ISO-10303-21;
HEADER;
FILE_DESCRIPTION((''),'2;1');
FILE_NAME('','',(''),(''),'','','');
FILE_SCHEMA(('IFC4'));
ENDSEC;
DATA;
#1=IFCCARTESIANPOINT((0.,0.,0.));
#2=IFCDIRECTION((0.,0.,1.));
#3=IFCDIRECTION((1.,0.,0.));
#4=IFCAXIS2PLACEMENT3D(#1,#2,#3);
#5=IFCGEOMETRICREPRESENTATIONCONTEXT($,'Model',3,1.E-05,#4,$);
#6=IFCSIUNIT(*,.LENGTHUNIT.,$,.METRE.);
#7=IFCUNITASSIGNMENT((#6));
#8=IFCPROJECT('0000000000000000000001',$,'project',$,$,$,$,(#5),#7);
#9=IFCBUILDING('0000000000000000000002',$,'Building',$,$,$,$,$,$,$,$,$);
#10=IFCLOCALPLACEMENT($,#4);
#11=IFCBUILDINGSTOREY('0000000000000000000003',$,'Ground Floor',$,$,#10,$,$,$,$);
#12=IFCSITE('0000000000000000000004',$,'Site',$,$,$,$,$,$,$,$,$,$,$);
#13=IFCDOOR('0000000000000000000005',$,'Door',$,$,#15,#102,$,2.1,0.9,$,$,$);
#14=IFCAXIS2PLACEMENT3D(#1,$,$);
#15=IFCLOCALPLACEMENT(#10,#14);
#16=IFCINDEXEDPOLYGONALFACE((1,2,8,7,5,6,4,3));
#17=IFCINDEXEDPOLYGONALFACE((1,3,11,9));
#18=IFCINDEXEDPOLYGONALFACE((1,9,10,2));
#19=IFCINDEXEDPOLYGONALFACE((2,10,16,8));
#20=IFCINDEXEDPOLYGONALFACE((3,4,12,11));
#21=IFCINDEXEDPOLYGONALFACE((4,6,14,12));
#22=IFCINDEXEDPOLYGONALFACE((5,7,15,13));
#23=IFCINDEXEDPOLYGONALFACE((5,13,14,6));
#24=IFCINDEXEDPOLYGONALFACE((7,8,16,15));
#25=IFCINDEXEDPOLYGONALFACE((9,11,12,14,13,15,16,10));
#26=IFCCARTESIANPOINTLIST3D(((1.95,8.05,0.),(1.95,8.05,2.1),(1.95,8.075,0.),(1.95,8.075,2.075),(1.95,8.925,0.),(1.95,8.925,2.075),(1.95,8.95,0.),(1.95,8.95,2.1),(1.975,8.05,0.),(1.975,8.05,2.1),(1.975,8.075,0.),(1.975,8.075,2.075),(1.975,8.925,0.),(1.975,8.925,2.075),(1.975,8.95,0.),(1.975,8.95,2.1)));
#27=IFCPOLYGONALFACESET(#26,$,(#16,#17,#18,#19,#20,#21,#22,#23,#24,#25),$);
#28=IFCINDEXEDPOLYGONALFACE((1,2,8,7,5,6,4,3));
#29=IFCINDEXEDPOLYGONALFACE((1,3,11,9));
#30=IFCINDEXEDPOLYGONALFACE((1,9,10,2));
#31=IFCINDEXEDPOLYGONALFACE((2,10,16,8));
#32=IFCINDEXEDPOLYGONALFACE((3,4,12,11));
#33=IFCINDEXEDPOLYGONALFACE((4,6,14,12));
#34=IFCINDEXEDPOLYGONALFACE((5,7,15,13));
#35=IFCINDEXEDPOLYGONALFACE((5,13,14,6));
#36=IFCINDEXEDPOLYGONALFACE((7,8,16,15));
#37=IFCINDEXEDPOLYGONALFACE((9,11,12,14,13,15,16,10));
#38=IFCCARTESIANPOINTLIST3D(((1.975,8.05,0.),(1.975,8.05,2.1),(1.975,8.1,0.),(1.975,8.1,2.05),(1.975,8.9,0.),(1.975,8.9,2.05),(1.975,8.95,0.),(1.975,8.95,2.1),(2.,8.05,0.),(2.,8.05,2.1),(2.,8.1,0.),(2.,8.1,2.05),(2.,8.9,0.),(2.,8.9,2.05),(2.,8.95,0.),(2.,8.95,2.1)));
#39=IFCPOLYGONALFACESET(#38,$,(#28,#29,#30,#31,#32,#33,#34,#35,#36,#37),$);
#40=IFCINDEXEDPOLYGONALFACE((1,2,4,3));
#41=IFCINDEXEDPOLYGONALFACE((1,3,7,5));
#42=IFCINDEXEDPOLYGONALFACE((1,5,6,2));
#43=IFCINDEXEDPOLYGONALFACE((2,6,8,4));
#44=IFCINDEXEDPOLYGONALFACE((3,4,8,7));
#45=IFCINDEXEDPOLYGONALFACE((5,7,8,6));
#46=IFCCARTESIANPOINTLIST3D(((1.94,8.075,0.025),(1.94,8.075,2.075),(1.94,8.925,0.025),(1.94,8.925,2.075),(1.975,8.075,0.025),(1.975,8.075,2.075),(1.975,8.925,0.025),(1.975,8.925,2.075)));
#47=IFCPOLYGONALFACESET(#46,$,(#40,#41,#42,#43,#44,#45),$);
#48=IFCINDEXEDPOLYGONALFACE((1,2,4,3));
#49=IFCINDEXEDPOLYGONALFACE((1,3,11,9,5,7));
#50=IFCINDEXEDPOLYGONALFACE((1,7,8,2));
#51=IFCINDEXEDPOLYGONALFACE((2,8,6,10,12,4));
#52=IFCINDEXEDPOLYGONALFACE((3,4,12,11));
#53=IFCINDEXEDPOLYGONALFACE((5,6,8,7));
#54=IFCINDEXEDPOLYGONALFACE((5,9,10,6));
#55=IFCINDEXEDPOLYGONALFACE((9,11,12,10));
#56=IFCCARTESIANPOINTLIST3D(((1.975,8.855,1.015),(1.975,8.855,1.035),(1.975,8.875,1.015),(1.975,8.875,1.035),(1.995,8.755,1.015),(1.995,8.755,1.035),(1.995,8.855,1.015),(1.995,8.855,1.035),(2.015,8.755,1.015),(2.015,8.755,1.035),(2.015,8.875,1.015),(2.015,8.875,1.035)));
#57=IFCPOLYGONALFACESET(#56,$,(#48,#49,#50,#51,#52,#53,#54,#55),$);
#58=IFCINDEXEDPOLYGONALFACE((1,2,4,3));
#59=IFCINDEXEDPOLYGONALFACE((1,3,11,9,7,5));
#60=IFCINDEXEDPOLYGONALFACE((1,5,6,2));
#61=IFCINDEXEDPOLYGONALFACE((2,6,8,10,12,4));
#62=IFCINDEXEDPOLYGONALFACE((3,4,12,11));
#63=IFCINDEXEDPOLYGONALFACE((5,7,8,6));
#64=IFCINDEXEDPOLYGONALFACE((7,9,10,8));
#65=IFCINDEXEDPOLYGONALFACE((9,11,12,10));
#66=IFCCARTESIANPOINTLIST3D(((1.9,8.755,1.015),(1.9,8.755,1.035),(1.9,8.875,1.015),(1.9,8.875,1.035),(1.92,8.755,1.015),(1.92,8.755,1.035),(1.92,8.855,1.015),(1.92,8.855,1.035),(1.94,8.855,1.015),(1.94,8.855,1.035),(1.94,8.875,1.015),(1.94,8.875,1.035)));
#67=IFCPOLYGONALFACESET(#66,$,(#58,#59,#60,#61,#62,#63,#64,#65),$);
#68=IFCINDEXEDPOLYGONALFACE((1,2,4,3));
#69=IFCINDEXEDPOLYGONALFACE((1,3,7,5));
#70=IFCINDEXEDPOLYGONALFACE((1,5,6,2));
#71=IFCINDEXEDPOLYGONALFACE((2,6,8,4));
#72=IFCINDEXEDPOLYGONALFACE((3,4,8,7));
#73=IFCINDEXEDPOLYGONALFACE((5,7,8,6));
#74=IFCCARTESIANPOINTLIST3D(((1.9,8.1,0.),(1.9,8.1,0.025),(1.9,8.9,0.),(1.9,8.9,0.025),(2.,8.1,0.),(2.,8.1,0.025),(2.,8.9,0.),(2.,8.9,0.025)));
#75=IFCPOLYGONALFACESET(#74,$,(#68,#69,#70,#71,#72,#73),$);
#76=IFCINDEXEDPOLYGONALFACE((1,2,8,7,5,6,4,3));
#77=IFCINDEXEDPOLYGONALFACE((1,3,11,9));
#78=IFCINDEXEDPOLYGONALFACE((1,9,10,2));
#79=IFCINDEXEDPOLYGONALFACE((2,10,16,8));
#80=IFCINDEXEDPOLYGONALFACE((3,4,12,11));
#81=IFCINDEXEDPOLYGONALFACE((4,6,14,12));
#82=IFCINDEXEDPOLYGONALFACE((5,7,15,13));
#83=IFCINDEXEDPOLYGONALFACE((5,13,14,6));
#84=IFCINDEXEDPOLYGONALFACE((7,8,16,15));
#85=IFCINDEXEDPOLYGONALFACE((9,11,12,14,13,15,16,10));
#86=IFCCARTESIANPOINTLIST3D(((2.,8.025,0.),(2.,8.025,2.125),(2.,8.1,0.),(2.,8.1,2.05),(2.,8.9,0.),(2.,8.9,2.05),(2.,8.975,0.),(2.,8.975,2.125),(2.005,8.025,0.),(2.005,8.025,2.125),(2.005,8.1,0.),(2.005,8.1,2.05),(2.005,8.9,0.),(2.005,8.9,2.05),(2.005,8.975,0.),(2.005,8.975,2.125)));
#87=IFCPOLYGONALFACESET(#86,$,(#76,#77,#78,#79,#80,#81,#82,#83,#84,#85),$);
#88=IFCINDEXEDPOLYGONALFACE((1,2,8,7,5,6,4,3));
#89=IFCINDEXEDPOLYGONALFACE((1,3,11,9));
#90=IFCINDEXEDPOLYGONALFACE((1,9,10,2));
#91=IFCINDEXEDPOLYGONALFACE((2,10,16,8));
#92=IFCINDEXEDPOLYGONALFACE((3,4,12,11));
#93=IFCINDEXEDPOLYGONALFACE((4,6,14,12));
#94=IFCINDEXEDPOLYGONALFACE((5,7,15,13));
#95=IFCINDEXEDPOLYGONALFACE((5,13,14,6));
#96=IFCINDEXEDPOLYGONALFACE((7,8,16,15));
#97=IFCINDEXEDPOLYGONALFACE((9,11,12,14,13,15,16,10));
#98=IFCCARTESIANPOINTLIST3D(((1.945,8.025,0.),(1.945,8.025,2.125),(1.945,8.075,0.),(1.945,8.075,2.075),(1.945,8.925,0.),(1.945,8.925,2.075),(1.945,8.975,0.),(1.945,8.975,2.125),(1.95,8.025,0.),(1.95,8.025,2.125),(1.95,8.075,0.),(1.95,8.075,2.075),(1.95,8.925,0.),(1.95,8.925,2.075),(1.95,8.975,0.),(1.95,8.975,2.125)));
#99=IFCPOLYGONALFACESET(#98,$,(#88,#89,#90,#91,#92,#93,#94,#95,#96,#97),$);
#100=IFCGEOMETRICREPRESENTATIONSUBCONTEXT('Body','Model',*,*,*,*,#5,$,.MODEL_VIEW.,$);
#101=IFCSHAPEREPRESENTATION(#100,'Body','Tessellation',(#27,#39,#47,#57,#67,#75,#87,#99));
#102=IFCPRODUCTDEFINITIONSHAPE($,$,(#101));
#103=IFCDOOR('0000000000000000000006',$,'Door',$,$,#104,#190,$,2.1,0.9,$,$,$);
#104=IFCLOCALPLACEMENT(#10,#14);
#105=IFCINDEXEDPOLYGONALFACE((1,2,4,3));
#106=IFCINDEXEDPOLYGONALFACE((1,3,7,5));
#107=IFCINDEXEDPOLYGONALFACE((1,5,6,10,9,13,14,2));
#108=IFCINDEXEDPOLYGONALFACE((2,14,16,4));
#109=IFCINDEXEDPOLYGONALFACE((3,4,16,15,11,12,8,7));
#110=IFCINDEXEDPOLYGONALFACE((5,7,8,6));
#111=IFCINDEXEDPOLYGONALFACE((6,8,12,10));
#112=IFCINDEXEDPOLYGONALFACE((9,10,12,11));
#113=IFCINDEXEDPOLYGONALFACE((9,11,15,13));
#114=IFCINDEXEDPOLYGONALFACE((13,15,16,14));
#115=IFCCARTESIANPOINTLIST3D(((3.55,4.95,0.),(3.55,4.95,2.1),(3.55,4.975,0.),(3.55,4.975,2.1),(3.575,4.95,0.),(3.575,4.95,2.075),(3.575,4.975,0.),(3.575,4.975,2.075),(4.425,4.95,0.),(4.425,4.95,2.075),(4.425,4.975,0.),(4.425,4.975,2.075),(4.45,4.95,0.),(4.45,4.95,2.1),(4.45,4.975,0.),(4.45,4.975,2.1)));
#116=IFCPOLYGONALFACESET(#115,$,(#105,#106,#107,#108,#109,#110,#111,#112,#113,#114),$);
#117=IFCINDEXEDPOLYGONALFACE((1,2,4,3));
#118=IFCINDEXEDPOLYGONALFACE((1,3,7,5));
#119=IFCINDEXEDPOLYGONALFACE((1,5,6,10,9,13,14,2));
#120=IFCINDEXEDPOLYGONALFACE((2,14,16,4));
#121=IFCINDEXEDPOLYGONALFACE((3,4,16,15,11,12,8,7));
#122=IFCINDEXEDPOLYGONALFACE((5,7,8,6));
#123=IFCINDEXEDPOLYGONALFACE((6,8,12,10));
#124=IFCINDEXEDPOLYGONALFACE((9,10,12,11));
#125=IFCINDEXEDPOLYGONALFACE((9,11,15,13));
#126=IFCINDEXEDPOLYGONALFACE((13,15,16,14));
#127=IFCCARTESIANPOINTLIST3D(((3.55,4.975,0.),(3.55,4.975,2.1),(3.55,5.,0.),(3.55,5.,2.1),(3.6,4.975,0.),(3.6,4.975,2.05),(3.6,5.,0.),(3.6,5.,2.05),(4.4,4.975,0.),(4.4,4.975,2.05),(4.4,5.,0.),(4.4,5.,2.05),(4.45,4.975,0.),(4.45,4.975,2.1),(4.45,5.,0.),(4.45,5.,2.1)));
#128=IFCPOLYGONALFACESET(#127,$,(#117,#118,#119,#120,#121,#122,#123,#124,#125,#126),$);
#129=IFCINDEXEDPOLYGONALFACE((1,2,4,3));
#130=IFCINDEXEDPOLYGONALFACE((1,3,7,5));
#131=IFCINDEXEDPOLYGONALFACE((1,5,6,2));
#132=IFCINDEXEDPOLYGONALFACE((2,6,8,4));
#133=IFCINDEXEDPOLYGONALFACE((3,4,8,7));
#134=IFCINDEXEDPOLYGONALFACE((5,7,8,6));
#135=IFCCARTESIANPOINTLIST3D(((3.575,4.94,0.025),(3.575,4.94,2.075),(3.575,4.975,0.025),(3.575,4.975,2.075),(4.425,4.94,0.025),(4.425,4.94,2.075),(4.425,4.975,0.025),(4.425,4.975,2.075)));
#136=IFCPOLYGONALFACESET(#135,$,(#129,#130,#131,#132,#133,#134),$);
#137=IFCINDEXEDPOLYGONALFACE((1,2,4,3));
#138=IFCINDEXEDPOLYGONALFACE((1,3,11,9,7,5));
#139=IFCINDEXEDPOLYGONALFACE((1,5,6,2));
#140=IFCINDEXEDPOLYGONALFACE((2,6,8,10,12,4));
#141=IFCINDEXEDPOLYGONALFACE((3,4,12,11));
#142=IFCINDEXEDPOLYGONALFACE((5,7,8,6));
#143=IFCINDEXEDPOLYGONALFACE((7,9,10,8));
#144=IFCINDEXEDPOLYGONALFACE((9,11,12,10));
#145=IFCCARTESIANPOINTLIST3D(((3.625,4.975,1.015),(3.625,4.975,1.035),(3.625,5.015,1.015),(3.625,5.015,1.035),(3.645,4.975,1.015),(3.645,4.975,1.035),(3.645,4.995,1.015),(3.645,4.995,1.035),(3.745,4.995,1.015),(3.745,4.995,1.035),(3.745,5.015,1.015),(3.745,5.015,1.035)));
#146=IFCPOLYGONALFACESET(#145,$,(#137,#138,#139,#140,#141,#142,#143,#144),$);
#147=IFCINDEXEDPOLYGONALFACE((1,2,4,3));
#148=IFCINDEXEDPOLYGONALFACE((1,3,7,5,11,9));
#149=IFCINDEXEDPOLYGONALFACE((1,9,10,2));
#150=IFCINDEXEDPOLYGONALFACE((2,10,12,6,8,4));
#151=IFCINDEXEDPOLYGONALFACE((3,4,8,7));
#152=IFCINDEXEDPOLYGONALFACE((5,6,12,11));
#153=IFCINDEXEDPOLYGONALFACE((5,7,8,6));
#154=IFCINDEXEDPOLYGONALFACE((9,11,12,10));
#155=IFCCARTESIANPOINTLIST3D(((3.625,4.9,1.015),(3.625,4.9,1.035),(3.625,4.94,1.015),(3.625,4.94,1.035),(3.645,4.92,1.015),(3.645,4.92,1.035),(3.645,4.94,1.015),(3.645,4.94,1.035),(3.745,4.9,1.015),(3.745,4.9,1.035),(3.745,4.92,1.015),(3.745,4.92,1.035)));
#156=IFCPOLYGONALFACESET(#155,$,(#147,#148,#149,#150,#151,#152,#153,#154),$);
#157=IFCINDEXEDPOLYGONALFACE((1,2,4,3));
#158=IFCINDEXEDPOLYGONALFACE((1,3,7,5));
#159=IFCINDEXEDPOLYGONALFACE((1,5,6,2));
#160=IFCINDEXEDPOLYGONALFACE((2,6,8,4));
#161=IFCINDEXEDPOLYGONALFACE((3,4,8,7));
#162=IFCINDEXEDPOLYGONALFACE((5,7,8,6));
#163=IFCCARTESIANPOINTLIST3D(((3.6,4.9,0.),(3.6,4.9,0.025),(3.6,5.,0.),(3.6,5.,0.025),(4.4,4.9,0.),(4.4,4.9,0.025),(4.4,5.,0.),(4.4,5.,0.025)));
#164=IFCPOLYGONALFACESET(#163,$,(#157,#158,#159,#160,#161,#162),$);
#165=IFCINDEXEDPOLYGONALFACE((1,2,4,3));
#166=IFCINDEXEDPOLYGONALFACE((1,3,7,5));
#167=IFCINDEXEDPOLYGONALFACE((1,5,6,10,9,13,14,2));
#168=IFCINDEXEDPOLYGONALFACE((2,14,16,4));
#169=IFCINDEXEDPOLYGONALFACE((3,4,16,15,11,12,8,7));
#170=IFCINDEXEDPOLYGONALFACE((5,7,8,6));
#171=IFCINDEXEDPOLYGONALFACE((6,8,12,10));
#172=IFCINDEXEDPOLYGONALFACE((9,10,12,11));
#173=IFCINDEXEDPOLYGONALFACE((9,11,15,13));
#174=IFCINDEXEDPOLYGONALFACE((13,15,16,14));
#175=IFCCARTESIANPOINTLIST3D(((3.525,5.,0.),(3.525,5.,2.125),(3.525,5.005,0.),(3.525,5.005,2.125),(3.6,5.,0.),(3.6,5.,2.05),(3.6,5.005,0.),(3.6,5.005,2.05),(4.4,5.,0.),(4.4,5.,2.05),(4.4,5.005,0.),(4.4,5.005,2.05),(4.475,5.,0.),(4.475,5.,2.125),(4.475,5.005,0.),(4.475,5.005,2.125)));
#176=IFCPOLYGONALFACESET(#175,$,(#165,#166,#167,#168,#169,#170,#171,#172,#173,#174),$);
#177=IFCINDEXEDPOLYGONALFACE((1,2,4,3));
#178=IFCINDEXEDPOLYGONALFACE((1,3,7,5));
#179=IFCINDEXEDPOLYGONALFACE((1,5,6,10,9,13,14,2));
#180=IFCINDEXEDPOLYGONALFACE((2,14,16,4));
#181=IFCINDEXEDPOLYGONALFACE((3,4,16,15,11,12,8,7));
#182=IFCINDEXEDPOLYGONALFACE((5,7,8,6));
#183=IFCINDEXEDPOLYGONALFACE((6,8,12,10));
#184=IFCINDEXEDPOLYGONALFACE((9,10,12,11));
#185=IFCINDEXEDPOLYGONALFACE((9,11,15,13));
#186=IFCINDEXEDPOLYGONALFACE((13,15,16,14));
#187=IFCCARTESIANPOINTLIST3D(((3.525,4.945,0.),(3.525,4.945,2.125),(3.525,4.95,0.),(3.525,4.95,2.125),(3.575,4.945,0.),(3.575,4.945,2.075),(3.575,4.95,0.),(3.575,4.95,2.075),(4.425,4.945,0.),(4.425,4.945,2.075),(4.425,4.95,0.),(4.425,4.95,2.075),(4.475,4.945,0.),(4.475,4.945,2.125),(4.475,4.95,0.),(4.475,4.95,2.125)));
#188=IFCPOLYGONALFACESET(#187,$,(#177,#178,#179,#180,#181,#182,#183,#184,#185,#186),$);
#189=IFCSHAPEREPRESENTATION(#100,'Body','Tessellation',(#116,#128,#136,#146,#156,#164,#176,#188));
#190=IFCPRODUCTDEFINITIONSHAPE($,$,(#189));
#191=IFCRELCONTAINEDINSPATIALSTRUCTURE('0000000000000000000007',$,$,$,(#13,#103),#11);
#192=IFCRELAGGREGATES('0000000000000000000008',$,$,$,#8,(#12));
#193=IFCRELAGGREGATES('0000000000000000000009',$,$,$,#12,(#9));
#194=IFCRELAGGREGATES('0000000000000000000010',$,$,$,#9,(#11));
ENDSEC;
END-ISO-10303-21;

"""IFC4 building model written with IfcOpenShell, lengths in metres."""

from ifc_helpers import new_model, si_unit, frame, origin_with_axes, place, context, subcontext, project, spatial, line, indexed_curve, outline, extrude, element, save


model = new_model("IFC4")

# Units and contexts
model_context = context("Model", 3, precision=1e-05, world=origin_with_axes())
body_context = subcontext(model_context, "Body", "Model", "MODEL_VIEW")
ifc_project = project(units=[si_unit("LENGTHUNIT", "METRE")], contexts=[model_context])

# Site, building, storey
site = spatial("IfcSite", under=ifc_project, Name="Site")
building = spatial("IfcBuilding", under=site, Name="Building")
storey_placement = place(None, origin_with_axes())
storey = spatial("IfcBuildingStorey", under=building, at=storey_placement, Name="Ground Floor")

# Doors
door_1_placement = place(storey_placement, frame((2.0, 8.05, 0.0), z_axis=(0.0, 0.0, 1.0), x_axis=(0.0, 1.0, 0.0)))
element("IfcDoor", 1, at=door_1_placement, inside=storey, Name="Door", OverallHeight=2.1, OverallWidth=0.9, context=body_context, shape_type="SweptSolid", body=[
    extrude(outline(indexed_curve([(0.0, 0.0), (0.0, 2.1), (0.9, 2.1), (0.9, 0.0), (0.875, 0.0), (0.875, 2.075), (0.025, 2.075), (0.025, 0.0)], segments=[line(1, 2, 3, 4, 5, 6, 7, 8, 1)])), frame((0.0, 0.025, 0.0), z_axis=(0.0, -1.0, 0.0), x_axis=(1.0, 0.0, 0.0)), (0.0, 0.0, -1.0), 0.025),
    extrude(outline(indexed_curve([(0.0, 0.0), (0.0, 2.1), (0.9, 2.1), (0.9, 0.0), (0.85, 0.0), (0.85, 2.05), (0.05, 2.05), (0.05, 0.0)], segments=[line(1, 2, 3, 4, 5, 6, 7, 8, 1)])), frame((0.0, 0.0, 0.0), z_axis=(0.0, -1.0, 0.0), x_axis=(1.0, 0.0, 0.0)), (0.0, 0.0, -1.0), 0.025),
    extrude(outline(indexed_curve([(0.0, 0.0), (0.85, 0.0), (0.85, 0.035), (0.0, 0.035)], segments=[line(1, 2, 3, 4, 1)])), frame((0.025, 0.025, 0.025), z_axis=(0.0, 0.0, 1.0), x_axis=(1.0, 0.0, 0.0)), (0.0, 0.0, 1.0), 2.05),
    extrude(outline(indexed_curve([(0.0, 0.0), (0.0, -0.04), (-0.12, -0.04), (-0.12, -0.02), (-0.02, -0.02), (-0.02, 0.0)], segments=[line(1, 2, 3, 4, 5, 6, 1)])), frame((0.825, 0.025, 1.015), z_axis=(0.0, 0.0, 1.0), x_axis=(1.0, 0.0, 0.0)), (0.0, 0.0, 1.0), 0.02),
    extrude(outline(indexed_curve([(0.0, 0.0), (0.0, 0.04), (-0.12, 0.04), (-0.12, 0.02), (-0.02, 0.02), (-0.02, 0.0)], segments=[line(1, 2, 3, 4, 5, 6, 1)])), frame((0.825, 0.06, 1.015), z_axis=(0.0, 0.0, 1.0), x_axis=(1.0, 0.0, 0.0)), (0.0, 0.0, 1.0), 0.02),
    extrude(outline(indexed_curve([(0.0, 0.0), (0.8, 0.0), (0.8, 0.1), (0.0, 0.1)], segments=[line(1, 2, 3, 4, 1)])), frame((0.05, 0.0, 0.0), z_axis=(0.0, 0.0, 1.0), x_axis=(1.0, 0.0, 0.0)), (0.0, 0.0, 1.0), 0.025),
    extrude(outline(indexed_curve([(0.0, 0.0), (0.0, 2.125), (0.95, 2.125), (0.95, 0.0), (0.875, 0.0), (0.875, 2.05), (0.075, 2.05), (0.075, 0.0)], segments=[line(1, 2, 3, 4, 5, 6, 7, 8, 1)])), frame((-0.025, -0.005, 0.0), z_axis=(0.0, -1.0, 0.0), x_axis=(1.0, 0.0, 0.0)), (0.0, 0.0, -1.0), 0.005),
    extrude(outline(indexed_curve([(0.0, 0.0), (0.0, 2.125), (0.95, 2.125), (0.95, 0.0), (0.9, 0.0), (0.9, 2.075), (0.05, 2.075), (0.05, 0.0)], segments=[line(1, 2, 3, 4, 5, 6, 7, 8, 1)])), frame((-0.025, 0.05, 0.0), z_axis=(0.0, -1.0, 0.0), x_axis=(1.0, 0.0, 0.0)), (0.0, 0.0, -1.0), 0.005),
])
door_2_placement = place(storey_placement, frame((4.45, 5.0, 0.0), z_axis=(0.0, 0.0, 1.0), x_axis=(-1.0, 0.0, 0.0)))
element("IfcDoor", 2, at=door_2_placement, inside=storey, Name="Door", OverallHeight=2.1, OverallWidth=0.9, context=body_context, shape_type="SweptSolid", body=[
    extrude(outline(indexed_curve([(0.0, 0.0), (0.0, 2.1), (0.9, 2.1), (0.9, 0.0), (0.875, 0.0), (0.875, 2.075), (0.025, 2.075), (0.025, 0.0)], segments=[line(1, 2, 3, 4, 5, 6, 7, 8, 1)])), frame((0.0, 0.025, 0.0), z_axis=(0.0, -1.0, 0.0), x_axis=(1.0, 0.0, 0.0)), (0.0, 0.0, -1.0), 0.025),
    extrude(outline(indexed_curve([(0.0, 0.0), (0.0, 2.1), (0.9, 2.1), (0.9, 0.0), (0.85, 0.0), (0.85, 2.05), (0.05, 2.05), (0.05, 0.0)], segments=[line(1, 2, 3, 4, 5, 6, 7, 8, 1)])), frame((0.0, 0.0, 0.0), z_axis=(0.0, -1.0, 0.0), x_axis=(1.0, 0.0, 0.0)), (0.0, 0.0, -1.0), 0.025),
    extrude(outline(indexed_curve([(0.0, 0.0), (0.85, 0.0), (0.85, 0.035), (0.0, 0.035)], segments=[line(1, 2, 3, 4, 1)])), frame((0.025, 0.025, 0.025), z_axis=(0.0, 0.0, 1.0), x_axis=(1.0, 0.0, 0.0)), (0.0, 0.0, 1.0), 2.05),
    extrude(outline(indexed_curve([(0.0, 0.0), (0.0, -0.04), (-0.12, -0.04), (-0.12, -0.02), (-0.02, -0.02), (-0.02, 0.0)], segments=[line(1, 2, 3, 4, 5, 6, 1)])), frame((0.825, 0.025, 1.015), z_axis=(0.0, 0.0, 1.0), x_axis=(1.0, 0.0, 0.0)), (0.0, 0.0, 1.0), 0.02),
    extrude(outline(indexed_curve([(0.0, 0.0), (0.0, 0.04), (-0.12, 0.04), (-0.12, 0.02), (-0.02, 0.02), (-0.02, 0.0)], segments=[line(1, 2, 3, 4, 5, 6, 1)])), frame((0.825, 0.06, 1.015), z_axis=(0.0, 0.0, 1.0), x_axis=(1.0, 0.0, 0.0)), (0.0, 0.0, 1.0), 0.02),
    extrude(outline(indexed_curve([(0.0, 0.0), (0.8, 0.0), (0.8, 0.1), (0.0, 0.1)], segments=[line(1, 2, 3, 4, 1)])), frame((0.05, 0.0, 0.0), z_axis=(0.0, 0.0, 1.0), x_axis=(1.0, 0.0, 0.0)), (0.0, 0.0, 1.0), 0.025),
    extrude(outline(indexed_curve([(0.0, 0.0), (0.0, 2.125), (0.95, 2.125), (0.95, 0.0), (0.875, 0.0), (0.875, 2.05), (0.075, 2.05), (0.075, 0.0)], segments=[line(1, 2, 3, 4, 5, 6, 7, 8, 1)])), frame((-0.025, -0.005, 0.0), z_axis=(0.0, -1.0, 0.0), x_axis=(1.0, 0.0, 0.0)), (0.0, 0.0, -1.0), 0.005),
    extrude(outline(indexed_curve([(0.0, 0.0), (0.0, 2.125), (0.95, 2.125), (0.95, 0.0), (0.9, 0.0), (0.9, 2.075), (0.05, 2.075), (0.05, 0.0)], segments=[line(1, 2, 3, 4, 5, 6, 7, 8, 1)])), frame((-0.025, 0.05, 0.0), z_axis=(0.0, -1.0, 0.0), x_axis=(1.0, 0.0, 0.0)), (0.0, 0.0, -1.0), 0.005),
])

save(model, "model.ifc")
